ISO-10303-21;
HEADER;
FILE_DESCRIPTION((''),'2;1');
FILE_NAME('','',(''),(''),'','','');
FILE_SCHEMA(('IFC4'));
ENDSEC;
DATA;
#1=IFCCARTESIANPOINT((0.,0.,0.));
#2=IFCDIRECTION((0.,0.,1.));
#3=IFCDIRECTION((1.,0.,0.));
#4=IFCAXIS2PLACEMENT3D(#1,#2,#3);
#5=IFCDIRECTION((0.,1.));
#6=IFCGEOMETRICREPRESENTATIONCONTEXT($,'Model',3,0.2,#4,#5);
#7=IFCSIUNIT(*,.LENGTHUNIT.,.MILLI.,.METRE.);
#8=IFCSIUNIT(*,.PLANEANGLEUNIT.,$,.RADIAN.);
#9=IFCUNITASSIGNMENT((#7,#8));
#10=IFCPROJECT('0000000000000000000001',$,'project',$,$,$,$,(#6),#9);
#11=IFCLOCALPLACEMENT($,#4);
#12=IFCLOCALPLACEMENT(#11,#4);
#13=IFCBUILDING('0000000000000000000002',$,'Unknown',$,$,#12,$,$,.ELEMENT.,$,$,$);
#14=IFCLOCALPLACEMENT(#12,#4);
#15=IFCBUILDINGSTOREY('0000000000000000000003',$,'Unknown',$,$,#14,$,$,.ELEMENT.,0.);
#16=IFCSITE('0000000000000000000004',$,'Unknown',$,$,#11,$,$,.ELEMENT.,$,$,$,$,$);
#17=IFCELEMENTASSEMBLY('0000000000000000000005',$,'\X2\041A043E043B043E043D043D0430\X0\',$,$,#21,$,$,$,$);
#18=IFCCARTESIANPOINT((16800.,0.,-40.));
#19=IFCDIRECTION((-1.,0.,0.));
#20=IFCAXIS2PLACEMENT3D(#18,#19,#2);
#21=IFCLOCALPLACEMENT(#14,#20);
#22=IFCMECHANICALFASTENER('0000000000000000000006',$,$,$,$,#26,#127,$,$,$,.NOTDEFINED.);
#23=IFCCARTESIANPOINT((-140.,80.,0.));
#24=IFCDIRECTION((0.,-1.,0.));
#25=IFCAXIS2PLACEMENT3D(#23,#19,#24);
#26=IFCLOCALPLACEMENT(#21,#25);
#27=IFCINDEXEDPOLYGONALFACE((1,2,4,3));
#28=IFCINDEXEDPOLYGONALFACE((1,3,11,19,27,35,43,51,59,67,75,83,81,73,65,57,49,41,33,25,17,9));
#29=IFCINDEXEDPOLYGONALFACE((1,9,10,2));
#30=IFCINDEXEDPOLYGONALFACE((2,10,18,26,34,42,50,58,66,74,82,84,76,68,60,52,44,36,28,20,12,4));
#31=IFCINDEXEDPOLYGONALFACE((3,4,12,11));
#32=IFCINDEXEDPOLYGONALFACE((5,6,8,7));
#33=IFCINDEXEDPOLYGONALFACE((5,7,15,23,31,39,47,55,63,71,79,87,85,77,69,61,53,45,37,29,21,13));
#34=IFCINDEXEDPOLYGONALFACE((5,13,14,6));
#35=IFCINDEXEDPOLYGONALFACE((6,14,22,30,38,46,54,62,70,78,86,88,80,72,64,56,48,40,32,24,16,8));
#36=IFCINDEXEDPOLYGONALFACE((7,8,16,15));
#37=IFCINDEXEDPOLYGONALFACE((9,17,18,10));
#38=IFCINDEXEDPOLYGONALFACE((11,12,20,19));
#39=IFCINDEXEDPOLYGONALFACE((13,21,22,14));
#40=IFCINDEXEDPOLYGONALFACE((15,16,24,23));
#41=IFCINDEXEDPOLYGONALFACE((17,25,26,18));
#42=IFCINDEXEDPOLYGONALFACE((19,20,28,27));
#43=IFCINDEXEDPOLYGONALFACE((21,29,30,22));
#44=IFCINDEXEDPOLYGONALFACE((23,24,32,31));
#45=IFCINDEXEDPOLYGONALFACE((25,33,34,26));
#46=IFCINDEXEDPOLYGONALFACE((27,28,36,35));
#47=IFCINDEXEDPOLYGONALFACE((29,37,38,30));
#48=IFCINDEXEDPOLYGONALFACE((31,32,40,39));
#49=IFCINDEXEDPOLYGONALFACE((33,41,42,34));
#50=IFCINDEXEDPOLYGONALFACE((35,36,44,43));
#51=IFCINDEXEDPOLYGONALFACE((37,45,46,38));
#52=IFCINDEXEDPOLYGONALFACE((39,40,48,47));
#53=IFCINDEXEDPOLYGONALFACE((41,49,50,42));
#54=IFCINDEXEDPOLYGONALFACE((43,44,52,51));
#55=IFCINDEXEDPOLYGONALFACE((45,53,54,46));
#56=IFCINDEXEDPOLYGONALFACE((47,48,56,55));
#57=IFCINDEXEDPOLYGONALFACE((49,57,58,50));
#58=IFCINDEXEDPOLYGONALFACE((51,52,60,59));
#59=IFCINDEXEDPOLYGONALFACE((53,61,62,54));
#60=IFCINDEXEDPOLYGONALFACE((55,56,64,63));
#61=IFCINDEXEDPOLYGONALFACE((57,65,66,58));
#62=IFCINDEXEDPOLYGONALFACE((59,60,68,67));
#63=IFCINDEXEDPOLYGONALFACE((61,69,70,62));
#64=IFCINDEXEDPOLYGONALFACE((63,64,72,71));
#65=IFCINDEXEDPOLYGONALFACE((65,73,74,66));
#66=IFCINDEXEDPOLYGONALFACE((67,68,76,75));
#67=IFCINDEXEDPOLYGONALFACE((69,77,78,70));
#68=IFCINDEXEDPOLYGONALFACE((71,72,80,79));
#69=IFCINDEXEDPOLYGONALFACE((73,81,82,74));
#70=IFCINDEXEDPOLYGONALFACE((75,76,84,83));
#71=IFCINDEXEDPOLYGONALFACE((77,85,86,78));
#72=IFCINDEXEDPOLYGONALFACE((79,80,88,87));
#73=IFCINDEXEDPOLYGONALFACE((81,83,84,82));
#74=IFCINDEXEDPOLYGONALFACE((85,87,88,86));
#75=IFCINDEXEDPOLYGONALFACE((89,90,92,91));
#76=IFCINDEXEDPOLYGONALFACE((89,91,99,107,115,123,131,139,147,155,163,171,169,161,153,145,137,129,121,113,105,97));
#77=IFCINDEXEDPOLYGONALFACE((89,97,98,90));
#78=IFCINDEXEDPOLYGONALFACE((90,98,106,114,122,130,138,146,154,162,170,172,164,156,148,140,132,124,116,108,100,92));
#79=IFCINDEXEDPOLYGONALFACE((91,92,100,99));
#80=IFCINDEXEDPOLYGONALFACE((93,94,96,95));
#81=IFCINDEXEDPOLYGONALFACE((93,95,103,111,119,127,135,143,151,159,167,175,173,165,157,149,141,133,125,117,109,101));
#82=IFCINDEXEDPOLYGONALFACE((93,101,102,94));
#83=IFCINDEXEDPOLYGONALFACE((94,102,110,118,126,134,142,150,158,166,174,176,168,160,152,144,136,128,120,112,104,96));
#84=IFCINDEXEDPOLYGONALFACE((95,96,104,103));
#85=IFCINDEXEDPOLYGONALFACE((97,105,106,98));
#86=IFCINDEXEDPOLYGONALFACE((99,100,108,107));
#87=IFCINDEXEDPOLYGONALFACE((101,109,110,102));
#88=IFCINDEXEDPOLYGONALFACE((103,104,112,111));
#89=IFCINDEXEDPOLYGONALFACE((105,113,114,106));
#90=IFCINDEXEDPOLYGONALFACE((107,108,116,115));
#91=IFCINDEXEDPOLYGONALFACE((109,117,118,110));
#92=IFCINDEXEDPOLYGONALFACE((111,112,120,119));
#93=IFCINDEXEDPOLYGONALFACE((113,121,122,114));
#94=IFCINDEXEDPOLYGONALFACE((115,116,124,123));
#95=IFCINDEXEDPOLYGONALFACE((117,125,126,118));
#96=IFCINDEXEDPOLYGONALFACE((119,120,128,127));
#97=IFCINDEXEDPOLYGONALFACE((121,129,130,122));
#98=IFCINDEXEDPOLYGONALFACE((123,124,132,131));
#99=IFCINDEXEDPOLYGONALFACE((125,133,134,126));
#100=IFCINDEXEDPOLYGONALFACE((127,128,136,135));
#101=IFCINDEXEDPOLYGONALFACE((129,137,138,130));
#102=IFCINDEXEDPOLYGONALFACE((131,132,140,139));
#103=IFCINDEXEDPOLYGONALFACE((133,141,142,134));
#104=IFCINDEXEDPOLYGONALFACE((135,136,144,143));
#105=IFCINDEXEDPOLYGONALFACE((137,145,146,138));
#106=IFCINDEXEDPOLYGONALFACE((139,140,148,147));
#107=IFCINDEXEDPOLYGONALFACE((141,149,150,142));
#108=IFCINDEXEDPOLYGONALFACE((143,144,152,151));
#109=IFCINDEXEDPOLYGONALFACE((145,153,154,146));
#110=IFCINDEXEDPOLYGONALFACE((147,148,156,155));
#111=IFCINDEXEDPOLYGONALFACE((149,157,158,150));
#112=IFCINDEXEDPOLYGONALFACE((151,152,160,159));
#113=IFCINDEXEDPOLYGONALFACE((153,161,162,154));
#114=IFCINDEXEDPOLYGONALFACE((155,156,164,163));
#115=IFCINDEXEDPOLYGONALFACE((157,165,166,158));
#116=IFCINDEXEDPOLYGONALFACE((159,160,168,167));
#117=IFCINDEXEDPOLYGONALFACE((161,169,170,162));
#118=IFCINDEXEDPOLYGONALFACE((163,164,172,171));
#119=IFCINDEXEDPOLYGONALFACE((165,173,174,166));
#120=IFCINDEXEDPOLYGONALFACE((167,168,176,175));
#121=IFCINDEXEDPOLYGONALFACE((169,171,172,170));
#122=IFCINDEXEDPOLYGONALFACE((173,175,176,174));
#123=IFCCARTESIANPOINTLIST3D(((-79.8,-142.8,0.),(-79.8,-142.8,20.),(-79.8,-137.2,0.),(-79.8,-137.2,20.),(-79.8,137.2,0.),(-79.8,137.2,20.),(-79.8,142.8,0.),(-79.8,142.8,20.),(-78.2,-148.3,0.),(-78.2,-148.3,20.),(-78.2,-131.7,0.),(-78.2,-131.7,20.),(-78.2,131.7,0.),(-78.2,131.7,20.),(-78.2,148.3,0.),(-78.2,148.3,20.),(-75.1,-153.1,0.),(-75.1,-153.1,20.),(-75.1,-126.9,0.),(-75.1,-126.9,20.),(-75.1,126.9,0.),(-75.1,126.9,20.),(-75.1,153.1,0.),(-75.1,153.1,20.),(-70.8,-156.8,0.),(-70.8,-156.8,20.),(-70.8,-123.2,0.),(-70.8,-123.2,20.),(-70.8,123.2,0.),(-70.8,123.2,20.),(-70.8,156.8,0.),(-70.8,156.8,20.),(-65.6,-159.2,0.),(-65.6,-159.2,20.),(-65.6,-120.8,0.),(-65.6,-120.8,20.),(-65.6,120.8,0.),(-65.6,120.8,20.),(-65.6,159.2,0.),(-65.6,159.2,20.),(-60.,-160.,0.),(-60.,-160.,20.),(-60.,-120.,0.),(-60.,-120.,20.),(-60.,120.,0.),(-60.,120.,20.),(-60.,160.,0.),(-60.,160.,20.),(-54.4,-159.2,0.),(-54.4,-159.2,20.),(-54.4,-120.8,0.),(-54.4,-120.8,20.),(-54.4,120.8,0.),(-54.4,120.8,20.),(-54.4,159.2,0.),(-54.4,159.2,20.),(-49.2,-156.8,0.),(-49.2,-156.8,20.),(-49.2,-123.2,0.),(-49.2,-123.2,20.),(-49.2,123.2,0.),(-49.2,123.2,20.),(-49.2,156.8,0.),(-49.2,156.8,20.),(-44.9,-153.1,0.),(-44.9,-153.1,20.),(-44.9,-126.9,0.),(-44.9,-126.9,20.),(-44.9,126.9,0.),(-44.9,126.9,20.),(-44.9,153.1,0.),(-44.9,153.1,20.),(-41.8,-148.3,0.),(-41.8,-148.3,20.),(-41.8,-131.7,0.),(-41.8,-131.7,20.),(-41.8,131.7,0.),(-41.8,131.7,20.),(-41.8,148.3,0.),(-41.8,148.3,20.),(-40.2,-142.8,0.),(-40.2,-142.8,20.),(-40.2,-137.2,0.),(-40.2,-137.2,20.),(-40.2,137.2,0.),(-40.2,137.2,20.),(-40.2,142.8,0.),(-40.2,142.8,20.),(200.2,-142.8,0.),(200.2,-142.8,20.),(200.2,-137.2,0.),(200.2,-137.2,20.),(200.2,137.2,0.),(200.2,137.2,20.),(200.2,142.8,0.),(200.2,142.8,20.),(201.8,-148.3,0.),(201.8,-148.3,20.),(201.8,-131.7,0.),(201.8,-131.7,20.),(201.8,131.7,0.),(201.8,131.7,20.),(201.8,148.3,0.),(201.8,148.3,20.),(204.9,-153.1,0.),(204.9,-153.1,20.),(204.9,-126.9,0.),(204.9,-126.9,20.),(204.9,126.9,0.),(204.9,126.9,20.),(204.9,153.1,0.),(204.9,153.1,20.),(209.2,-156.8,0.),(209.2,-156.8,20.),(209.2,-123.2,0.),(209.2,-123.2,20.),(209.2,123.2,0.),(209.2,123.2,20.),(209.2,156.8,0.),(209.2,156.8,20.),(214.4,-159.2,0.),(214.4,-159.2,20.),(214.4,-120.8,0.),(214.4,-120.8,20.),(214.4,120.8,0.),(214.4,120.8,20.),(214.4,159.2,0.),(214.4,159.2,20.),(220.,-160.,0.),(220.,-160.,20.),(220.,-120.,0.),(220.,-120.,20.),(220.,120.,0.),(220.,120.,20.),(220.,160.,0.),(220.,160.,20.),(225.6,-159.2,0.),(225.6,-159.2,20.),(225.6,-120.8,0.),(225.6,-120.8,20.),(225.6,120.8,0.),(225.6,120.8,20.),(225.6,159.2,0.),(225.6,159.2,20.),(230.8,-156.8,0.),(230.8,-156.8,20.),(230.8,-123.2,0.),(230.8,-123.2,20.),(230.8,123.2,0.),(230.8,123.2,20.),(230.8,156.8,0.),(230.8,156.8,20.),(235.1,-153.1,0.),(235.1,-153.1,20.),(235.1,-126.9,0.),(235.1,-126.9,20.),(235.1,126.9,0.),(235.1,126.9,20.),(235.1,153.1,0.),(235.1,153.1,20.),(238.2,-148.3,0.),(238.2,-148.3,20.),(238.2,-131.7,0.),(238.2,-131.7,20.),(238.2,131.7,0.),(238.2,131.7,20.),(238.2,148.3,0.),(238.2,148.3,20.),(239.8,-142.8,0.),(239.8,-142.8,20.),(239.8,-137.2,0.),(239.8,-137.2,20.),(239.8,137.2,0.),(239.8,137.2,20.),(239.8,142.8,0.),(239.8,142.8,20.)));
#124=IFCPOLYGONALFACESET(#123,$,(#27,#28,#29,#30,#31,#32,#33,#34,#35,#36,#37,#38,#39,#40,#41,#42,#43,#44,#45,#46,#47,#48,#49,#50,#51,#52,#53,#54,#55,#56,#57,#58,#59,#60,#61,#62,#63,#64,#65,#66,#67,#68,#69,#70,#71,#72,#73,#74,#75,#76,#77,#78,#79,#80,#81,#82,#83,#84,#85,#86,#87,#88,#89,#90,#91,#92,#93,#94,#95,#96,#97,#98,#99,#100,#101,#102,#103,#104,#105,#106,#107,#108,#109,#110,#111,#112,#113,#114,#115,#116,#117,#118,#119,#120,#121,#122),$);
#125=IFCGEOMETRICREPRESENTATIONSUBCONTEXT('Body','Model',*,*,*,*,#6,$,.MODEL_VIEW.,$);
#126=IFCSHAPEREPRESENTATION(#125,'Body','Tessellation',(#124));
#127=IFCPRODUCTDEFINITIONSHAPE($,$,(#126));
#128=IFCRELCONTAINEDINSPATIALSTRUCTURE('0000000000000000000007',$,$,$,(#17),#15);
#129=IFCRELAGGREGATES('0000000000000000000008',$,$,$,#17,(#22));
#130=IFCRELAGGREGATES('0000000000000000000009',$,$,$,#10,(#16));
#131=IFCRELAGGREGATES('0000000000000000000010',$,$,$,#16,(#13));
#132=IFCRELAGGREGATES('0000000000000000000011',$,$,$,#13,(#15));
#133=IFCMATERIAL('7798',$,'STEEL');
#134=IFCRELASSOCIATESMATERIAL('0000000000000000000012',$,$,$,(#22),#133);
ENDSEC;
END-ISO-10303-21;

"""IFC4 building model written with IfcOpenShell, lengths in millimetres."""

from ifc_helpers import new_model, si_unit, direction, frame, origin_with_axes, place, context, subcontext, project, spatial, arc, indexed_curve, outline, extrude, source, transform, mapped, material, element, aggregate, save


model = new_model("IFC4")

# Units and contexts
model_context = context("Model", 3, precision=0.2, world=origin_with_axes(), true_north=direction((0.0, 1.0)))
body_context = subcontext(model_context, "Body", "Model", "MODEL_VIEW")
ifc_project = project(units=[si_unit("LENGTHUNIT", "METRE", prefix="MILLI"), si_unit("PLANEANGLEUNIT", "RADIAN")], contexts=[model_context])

# Site, building, storey
site_placement = place(None, origin_with_axes())
site = spatial("IfcSite", under=ifc_project, at=site_placement, Name="Unknown", CompositionType="ELEMENT")
building_placement = place(site_placement, origin_with_axes())
building = spatial("IfcBuilding", under=site, at=building_placement, Name="Unknown", CompositionType="ELEMENT")
storey_placement = place(building_placement, origin_with_axes())
storey = spatial("IfcBuildingStorey", under=building, at=storey_placement, Name="Unknown", CompositionType="ELEMENT", Elevation=0.0)

# Element assembly
assembly_1_placement = place(storey_placement, frame((16800.0, 0.0, -40.0), z_axis=(-1.0, 0.0, 0.0), x_axis=(0.0, 0.0, 1.0)))
assembly_1 = element("IfcElementAssembly", 1, at=assembly_1_placement, inside=storey, Name="Колонна")

# Mechanical fastener
ifc_material_1 = material(Name="7798", Category="STEEL")
shared_shape_1 = source(origin_with_axes(), body_context, "Body", "SweptSolid", [
    extrude(outline(indexed_curve([(20.0, 0.0), (0.0, 20.0), (-20.0, 0.0), (0.0, -20.0)], segments=[arc(1, 2, 3), arc(3, 4, 1)])), frame((0.0, 0.0, 20.0), z_axis=(0.0, 0.0, -1.0), x_axis=(0.0, 1.0, 0.0)), (0.0, 0.0, 1.0), 20.0),
])
mechanical_fastener_1_placement = place(assembly_1_placement, frame((-140.0, 80.0, 0.0), z_axis=(-1.0, 0.0, 0.0), x_axis=(0.0, -1.0, 0.0)))
mechanical_fastener_1 = element("IfcMechanicalFastener", 2, at=mechanical_fastener_1_placement, material=ifc_material_1, PredefinedType="NOTDEFINED", context=body_context, shape_type="MappedRepresentation", body=[
    mapped(shared_shape_1, transform((-60.0, -140.0, 0.0))),
    mapped(shared_shape_1, transform((-60.0, 140.0, 0.0))),
    mapped(shared_shape_1, transform((220.0, -140.0, 0.0))),
    mapped(shared_shape_1, transform((220.0, 140.0, 0.0))),
])
aggregate(assembly_1, [mechanical_fastener_1])

save(model, "model.ifc")
